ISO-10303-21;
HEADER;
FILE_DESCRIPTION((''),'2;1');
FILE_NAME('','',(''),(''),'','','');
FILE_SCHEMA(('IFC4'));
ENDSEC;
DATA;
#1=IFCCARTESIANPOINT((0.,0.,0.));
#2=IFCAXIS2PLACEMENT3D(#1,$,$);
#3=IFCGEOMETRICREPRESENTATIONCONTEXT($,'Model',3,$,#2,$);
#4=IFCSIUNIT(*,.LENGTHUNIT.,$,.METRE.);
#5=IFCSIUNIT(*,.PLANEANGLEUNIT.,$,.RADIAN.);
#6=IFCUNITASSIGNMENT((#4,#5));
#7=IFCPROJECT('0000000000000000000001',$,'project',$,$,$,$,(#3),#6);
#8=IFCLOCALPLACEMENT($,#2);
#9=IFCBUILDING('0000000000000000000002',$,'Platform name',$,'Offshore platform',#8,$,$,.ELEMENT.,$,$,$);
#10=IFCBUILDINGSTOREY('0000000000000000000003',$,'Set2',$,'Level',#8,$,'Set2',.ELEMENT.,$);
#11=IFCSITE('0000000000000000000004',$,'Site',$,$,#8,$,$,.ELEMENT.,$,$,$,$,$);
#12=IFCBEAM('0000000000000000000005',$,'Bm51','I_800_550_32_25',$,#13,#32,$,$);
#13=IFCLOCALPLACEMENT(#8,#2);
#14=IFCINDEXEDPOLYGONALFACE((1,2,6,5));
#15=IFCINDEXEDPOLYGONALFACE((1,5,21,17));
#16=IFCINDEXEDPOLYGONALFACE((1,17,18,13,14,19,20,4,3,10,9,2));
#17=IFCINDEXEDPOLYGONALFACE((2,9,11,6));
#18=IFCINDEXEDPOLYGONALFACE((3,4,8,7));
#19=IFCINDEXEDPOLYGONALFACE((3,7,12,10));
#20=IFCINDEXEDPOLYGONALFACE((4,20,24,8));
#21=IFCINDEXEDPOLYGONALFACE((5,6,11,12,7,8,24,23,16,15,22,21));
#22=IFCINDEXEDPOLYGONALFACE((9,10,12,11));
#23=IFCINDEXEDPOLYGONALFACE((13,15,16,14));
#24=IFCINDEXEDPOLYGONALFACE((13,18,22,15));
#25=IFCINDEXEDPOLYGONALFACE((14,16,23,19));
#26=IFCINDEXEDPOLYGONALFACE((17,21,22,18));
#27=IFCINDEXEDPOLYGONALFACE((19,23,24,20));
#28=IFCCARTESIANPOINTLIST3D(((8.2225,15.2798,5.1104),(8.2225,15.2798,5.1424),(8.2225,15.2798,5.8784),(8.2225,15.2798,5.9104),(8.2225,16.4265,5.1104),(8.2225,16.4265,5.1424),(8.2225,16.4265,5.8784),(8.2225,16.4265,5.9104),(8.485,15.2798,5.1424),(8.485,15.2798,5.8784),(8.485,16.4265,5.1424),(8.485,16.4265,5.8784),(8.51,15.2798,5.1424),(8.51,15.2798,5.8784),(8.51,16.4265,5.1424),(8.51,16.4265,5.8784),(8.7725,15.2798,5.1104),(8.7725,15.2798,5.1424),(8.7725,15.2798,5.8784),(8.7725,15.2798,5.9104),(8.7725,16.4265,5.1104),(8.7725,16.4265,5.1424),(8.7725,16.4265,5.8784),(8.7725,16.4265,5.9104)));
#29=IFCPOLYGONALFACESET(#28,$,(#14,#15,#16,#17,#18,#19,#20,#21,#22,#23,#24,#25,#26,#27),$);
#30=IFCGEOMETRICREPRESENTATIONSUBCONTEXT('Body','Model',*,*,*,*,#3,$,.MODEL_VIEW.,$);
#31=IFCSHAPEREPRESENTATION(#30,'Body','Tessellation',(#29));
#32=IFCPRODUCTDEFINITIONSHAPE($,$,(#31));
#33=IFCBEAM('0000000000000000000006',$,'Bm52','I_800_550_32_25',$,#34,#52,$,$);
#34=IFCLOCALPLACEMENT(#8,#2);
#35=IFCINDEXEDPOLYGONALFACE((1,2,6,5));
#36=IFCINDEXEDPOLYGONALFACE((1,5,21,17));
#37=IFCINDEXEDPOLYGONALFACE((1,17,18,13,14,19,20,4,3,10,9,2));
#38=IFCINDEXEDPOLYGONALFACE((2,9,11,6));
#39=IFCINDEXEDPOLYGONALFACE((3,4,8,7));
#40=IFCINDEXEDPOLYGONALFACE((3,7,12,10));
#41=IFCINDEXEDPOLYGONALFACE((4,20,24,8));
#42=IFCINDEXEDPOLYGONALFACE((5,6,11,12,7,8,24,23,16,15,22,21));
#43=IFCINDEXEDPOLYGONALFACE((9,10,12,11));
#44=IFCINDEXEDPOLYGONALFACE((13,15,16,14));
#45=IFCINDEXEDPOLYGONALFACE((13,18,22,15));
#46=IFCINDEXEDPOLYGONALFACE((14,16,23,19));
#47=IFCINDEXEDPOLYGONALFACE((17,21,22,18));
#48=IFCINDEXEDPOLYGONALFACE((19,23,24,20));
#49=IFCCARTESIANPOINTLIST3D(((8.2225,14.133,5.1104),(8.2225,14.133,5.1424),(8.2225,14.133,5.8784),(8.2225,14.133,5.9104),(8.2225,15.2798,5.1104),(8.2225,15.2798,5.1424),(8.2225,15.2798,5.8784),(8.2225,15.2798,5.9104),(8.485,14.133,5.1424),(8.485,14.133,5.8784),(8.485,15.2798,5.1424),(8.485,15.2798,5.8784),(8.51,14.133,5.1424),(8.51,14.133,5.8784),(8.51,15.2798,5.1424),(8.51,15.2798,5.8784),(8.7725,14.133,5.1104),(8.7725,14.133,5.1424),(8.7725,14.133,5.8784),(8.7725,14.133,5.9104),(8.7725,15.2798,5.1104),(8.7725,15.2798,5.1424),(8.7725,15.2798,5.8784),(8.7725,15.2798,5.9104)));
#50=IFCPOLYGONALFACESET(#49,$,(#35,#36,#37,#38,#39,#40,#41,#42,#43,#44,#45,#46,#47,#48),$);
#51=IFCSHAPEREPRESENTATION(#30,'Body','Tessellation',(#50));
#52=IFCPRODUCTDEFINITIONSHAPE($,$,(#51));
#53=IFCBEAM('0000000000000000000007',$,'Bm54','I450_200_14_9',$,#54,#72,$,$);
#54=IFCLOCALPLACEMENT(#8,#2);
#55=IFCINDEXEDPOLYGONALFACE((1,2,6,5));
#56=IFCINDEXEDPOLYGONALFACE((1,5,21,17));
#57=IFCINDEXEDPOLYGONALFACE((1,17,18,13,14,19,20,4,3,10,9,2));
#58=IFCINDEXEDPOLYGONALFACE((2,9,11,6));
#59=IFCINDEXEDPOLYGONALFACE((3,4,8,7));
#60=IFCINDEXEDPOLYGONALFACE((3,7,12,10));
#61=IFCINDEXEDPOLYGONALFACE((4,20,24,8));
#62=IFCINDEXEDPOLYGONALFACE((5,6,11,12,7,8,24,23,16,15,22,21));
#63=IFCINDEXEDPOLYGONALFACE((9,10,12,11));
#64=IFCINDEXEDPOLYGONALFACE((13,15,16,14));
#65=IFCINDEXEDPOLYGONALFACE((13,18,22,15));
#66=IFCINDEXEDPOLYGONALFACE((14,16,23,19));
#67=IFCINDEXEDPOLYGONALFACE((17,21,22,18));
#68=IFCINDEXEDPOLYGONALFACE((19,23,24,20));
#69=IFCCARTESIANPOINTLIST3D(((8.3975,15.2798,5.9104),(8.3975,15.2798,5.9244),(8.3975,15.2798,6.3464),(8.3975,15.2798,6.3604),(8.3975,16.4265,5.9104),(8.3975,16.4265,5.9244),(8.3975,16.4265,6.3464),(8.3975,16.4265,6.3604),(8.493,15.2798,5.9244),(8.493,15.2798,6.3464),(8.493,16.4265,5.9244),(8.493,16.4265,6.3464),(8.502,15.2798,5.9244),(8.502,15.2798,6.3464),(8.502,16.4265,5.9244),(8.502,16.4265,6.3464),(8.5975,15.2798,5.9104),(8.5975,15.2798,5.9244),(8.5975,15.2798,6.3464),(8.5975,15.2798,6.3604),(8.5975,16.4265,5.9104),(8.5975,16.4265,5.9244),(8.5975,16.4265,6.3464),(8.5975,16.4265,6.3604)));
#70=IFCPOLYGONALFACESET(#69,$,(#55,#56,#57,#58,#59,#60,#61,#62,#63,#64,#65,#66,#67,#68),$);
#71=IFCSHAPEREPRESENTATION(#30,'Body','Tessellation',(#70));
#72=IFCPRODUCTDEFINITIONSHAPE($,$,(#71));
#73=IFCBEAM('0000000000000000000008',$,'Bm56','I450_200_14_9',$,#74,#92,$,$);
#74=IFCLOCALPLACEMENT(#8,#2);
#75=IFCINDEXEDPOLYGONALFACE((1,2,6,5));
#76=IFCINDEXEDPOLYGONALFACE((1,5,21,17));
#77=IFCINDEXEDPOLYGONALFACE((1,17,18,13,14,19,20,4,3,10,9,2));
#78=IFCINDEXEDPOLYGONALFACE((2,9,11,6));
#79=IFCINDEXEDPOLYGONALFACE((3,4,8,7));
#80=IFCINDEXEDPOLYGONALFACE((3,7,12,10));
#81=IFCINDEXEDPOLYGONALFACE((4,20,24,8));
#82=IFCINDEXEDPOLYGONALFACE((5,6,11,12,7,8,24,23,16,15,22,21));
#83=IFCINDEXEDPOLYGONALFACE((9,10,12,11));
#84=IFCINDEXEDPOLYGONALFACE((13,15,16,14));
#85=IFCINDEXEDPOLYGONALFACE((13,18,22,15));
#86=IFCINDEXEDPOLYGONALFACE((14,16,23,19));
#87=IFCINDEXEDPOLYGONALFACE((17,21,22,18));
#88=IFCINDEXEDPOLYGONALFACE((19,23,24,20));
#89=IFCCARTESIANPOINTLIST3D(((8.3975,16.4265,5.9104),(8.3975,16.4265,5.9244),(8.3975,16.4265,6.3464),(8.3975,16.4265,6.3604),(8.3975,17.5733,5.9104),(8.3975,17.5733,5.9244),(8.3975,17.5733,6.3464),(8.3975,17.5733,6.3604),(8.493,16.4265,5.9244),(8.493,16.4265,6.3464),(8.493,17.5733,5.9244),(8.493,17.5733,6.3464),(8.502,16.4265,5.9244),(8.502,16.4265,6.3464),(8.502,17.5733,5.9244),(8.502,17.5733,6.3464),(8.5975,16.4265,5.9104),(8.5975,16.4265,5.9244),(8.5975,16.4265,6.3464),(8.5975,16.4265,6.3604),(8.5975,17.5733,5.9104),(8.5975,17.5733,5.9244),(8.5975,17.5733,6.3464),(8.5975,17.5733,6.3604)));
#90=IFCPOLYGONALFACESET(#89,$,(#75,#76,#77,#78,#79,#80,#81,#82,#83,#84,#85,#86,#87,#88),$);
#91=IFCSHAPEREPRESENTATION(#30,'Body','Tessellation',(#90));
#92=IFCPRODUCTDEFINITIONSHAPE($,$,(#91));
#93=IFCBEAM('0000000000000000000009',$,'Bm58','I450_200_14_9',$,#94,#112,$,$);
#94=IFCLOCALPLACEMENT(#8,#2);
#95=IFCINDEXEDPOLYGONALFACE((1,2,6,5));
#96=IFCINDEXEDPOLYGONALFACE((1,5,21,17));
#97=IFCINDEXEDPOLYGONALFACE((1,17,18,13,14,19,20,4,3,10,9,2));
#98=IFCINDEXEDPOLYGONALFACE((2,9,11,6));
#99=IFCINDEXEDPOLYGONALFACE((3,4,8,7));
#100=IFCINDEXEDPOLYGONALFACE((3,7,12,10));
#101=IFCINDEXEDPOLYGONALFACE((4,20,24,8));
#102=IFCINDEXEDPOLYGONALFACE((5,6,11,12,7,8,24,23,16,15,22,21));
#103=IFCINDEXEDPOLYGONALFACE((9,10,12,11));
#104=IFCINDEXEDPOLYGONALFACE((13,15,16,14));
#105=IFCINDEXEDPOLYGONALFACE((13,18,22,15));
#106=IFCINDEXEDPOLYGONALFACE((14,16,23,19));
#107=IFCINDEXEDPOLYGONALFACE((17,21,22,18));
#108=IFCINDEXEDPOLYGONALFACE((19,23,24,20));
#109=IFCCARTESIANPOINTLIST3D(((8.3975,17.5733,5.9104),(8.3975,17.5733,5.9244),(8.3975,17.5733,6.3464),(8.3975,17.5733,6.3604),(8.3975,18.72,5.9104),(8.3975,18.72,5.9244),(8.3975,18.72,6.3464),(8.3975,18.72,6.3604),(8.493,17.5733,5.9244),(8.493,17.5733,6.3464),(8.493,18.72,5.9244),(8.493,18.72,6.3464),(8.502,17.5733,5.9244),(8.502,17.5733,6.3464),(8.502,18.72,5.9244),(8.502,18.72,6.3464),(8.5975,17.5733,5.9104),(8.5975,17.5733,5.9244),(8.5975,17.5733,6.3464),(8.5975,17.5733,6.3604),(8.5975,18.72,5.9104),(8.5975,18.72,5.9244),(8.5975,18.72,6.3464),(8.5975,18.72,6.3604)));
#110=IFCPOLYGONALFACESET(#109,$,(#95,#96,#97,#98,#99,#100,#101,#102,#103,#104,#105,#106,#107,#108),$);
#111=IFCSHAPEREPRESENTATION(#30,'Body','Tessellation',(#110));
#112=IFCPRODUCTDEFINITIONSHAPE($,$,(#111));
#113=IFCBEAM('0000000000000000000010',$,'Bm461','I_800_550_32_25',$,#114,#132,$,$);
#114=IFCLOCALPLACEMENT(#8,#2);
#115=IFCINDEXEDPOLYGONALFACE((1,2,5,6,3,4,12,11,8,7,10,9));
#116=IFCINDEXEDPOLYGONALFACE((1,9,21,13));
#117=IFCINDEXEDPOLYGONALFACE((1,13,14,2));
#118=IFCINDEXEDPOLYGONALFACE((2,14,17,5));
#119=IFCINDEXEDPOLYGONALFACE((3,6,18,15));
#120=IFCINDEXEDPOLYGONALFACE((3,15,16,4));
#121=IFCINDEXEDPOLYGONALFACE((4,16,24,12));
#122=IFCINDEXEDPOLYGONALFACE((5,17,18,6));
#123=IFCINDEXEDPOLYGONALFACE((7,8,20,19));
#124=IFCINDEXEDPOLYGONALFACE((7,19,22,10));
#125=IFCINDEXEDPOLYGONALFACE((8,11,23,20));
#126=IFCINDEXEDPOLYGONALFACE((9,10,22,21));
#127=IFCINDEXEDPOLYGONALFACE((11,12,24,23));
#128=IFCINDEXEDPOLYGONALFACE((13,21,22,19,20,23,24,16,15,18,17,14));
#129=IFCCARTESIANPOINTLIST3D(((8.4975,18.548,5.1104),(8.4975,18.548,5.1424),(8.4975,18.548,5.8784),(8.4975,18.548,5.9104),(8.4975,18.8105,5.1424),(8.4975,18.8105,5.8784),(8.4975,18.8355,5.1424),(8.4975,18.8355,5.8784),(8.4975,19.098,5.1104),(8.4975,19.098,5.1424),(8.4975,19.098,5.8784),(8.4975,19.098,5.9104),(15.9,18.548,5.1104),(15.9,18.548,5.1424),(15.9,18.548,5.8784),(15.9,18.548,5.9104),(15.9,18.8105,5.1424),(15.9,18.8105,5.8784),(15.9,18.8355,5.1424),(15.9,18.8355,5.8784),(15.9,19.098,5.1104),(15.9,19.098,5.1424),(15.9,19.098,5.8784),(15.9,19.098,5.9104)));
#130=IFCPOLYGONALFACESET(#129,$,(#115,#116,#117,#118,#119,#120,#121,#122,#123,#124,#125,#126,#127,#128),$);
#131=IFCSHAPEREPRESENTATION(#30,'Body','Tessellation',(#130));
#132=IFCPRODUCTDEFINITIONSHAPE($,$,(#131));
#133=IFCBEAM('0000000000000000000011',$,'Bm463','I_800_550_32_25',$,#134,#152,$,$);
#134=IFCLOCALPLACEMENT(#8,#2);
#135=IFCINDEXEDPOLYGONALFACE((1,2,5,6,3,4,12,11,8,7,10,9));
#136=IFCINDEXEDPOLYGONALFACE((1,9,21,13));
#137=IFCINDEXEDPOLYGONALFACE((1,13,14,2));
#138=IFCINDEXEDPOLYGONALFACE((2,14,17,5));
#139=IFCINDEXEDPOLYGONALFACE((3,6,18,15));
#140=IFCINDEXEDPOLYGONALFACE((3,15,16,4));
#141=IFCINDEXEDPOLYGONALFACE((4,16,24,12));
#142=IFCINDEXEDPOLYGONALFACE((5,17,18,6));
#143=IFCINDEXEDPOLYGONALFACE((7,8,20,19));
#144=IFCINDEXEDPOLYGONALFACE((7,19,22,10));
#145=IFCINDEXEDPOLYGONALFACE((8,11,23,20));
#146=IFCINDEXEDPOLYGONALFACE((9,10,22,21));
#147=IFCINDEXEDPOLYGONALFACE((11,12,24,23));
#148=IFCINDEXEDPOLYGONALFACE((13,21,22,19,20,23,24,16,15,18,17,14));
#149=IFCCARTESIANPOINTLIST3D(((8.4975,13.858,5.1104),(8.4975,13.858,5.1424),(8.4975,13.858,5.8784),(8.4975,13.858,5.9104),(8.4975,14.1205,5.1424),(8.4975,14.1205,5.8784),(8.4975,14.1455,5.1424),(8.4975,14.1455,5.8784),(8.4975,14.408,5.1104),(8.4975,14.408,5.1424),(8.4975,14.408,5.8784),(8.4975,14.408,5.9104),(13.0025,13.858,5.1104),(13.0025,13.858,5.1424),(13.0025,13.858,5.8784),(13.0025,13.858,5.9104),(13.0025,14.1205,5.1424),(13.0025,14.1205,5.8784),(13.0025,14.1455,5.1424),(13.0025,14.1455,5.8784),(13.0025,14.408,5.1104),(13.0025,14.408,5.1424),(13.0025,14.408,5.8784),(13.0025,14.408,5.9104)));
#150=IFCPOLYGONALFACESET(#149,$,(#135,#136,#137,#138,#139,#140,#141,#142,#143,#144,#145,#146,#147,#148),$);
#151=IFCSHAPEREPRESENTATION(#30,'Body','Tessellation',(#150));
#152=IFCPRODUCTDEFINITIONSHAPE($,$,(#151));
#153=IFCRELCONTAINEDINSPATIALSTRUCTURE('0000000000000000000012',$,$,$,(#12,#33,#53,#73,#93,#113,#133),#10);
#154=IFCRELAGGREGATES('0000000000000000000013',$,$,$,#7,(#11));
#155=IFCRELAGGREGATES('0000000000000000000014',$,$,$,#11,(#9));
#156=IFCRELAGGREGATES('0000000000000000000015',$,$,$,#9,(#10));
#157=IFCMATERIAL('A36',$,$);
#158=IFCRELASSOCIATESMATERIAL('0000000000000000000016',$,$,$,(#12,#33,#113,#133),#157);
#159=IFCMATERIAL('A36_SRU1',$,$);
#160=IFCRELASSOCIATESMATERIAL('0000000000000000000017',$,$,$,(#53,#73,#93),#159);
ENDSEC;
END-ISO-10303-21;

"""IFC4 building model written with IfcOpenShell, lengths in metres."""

from ifc_helpers import new_model, si_unit, frame, origin, origin_2d, place, context, subcontext, project, spatial, i_section, extrude, source, transform, mapped, material, element, save


model = new_model("IFC4")

# Units and contexts
model_context = context("Model", 3, world=origin())
body_context = subcontext(model_context, "Body", "Model", "MODEL_VIEW")
ifc_project = project(units=[si_unit("LENGTHUNIT", "METRE"), si_unit("PLANEANGLEUNIT", "RADIAN")], contexts=[model_context])

# Site, building, storey
placement_1 = place(None, origin())
site = spatial("IfcSite", under=ifc_project, at=placement_1, Name="Site", CompositionType="ELEMENT")
building = spatial("IfcBuilding", under=site, at=placement_1, Name="Platform name", ObjectType="Offshore platform", CompositionType="ELEMENT")
storey = spatial("IfcBuildingStorey", under=building, at=placement_1, Name="Set2", ObjectType="Level", LongName="Set2", CompositionType="ELEMENT")

# Beams
ifc_material_1 = material(Name="A36")
ifc_material_2 = material(Name="A36_SRU1")
shared_shape_1 = source(origin(), body_context, "Body", "SweptSolid", [
    extrude(i_section(OverallWidth=0.55, OverallDepth=0.8, WebThickness=0.025, FlangeThickness=0.032, FilletRadius=0.0, at=origin_2d()), frame((0.0, 0.0, 0.0), z_axis=(0.0, -1.0, 0.0), x_axis=(1.0, 0.0, 0.0)), (0.0, 0.0, 1.0), 1.1467),
])
placement_2 = place(None, origin())
placement_3 = place(placement_2, origin())
placement_4 = place(placement_3, origin())
beam_1_placement = place(placement_4, frame((8.4975, 16.4265, 5.5104)))
element("IfcBeam", 1, at=beam_1_placement, inside=storey, material=ifc_material_1, Name="Bm51", Description="I_800_550_32_25", context=body_context, shape_type="MappedRepresentation", body=[
    mapped(shared_shape_1, transform((0.0, 0.0, 0.0), scale=1.0)),
])
shared_shape_2 = source(origin(), body_context, "Body", "SweptSolid", [
    extrude(i_section(OverallWidth=0.55, OverallDepth=0.8, WebThickness=0.025, FlangeThickness=0.032, FilletRadius=0.0, at=origin_2d()), frame((0.0, 0.0, 0.0), z_axis=(0.0, -1.0, 0.0), x_axis=(1.0, 0.0, 0.0)), (0.0, 0.0, 1.0), 1.1467),
])
placement_5 = place(None, origin())
placement_6 = place(placement_5, origin())
placement_7 = place(placement_6, origin())
beam_2_placement = place(placement_7, frame((8.4975, 15.2797, 5.5104)))
element("IfcBeam", 2, at=beam_2_placement, inside=storey, material=ifc_material_1, Name="Bm52", Description="I_800_550_32_25", context=body_context, shape_type="MappedRepresentation", body=[
    mapped(shared_shape_2, transform((0.0, 0.0, 0.0), scale=1.0)),
])
shared_shape_3 = source(origin(), body_context, "Body", "SweptSolid", [
    extrude(i_section(OverallWidth=0.2, OverallDepth=0.45, WebThickness=0.009, FlangeThickness=0.014, FilletRadius=0.0, at=origin_2d()), frame((0.0, 0.0, 0.0), z_axis=(0.0, 1.0, 0.0), x_axis=(-1.0, 0.0, 0.0)), (0.0, 0.0, 1.0), 1.1467),
])
placement_8 = place(None, origin())
placement_9 = place(placement_8, origin())
placement_10 = place(placement_9, origin())
beam_3_placement = place(placement_10, frame((8.4975, 15.2797, 6.1354)))
element("IfcBeam", 3, at=beam_3_placement, inside=storey, material=ifc_material_2, Name="Bm54", Description="I450_200_14_9", context=body_context, shape_type="MappedRepresentation", body=[
    mapped(shared_shape_3, transform((0.0, 0.0, 0.0), scale=1.0)),
])
shared_shape_4 = source(origin(), body_context, "Body", "SweptSolid", [
    extrude(i_section(OverallWidth=0.2, OverallDepth=0.45, WebThickness=0.009, FlangeThickness=0.014, FilletRadius=0.0, at=origin_2d()), frame((0.0, 0.0, 0.0), z_axis=(0.0, 1.0, 0.0), x_axis=(-1.0, 0.0, 0.0)), (0.0, 0.0, 1.0), 1.1467),
])
placement_11 = place(None, origin())
placement_12 = place(placement_11, origin())
placement_13 = place(placement_12, origin())
beam_4_placement = place(placement_13, frame((8.4975, 16.4265, 6.1354)))
element("IfcBeam", 4, at=beam_4_placement, inside=storey, material=ifc_material_2, Name="Bm56", Description="I450_200_14_9", context=body_context, shape_type="MappedRepresentation", body=[
    mapped(shared_shape_4, transform((0.0, 0.0, 0.0), scale=1.0)),
])
shared_shape_5 = source(origin(), body_context, "Body", "SweptSolid", [
    extrude(i_section(OverallWidth=0.2, OverallDepth=0.45, WebThickness=0.009, FlangeThickness=0.014, FilletRadius=0.0, at=origin_2d()), frame((0.0, 0.0, 0.0), z_axis=(0.0, 1.0, 0.0), x_axis=(-1.0, 0.0, 0.0)), (0.0, 0.0, 1.0), 1.1467),
])
placement_14 = place(None, origin())
placement_15 = place(placement_14, origin())
placement_16 = place(placement_15, origin())
beam_5_placement = place(placement_16, frame((8.4975, 17.5733, 6.1354)))
element("IfcBeam", 5, at=beam_5_placement, inside=storey, material=ifc_material_2, Name="Bm58", Description="I450_200_14_9", context=body_context, shape_type="MappedRepresentation", body=[
    mapped(shared_shape_5, transform((0.0, 0.0, 0.0), scale=1.0)),
])
shared_shape_6 = source(origin(), body_context, "Body", "SweptSolid", [
    extrude(i_section(OverallWidth=0.55, OverallDepth=0.8, WebThickness=0.025, FlangeThickness=0.032, FilletRadius=0.0, at=origin_2d()), frame((0.0, 0.0, 0.0), z_axis=(1.0, 0.0, 0.0), x_axis=(0.0, 1.0, 0.0)), (0.0, 0.0, 1.0), 7.4025),
])
placement_17 = place(None, origin())
placement_18 = place(placement_17, origin())
placement_19 = place(placement_18, origin())
beam_6_placement = place(placement_19, frame((8.4975, 18.823, 5.5104)))
element("IfcBeam", 6, at=beam_6_placement, inside=storey, material=ifc_material_1, Name="Bm461", Description="I_800_550_32_25", context=body_context, shape_type="MappedRepresentation", body=[
    mapped(shared_shape_6, transform((0.0, 0.0, 0.0), scale=1.0)),
])
shared_shape_7 = source(origin(), body_context, "Body", "SweptSolid", [
    extrude(i_section(OverallWidth=0.55, OverallDepth=0.8, WebThickness=0.025, FlangeThickness=0.032, FilletRadius=0.0, at=origin_2d()), frame((0.0, 0.0, 0.0), z_axis=(1.0, 0.0, 0.0), x_axis=(0.0, 1.0, 0.0)), (0.0, 0.0, 1.0), 4.505),
])
placement_20 = place(None, origin())
placement_21 = place(placement_20, origin())
placement_22 = place(placement_21, origin())
beam_7_placement = place(placement_22, frame((8.4975, 14.133, 5.5104)))
element("IfcBeam", 7, at=beam_7_placement, inside=storey, material=ifc_material_1, Name="Bm463", Description="I_800_550_32_25", context=body_context, shape_type="MappedRepresentation", body=[
    mapped(shared_shape_7, transform((0.0, 0.0, 0.0), scale=1.0)),
])

save(model, "model.ifc")
